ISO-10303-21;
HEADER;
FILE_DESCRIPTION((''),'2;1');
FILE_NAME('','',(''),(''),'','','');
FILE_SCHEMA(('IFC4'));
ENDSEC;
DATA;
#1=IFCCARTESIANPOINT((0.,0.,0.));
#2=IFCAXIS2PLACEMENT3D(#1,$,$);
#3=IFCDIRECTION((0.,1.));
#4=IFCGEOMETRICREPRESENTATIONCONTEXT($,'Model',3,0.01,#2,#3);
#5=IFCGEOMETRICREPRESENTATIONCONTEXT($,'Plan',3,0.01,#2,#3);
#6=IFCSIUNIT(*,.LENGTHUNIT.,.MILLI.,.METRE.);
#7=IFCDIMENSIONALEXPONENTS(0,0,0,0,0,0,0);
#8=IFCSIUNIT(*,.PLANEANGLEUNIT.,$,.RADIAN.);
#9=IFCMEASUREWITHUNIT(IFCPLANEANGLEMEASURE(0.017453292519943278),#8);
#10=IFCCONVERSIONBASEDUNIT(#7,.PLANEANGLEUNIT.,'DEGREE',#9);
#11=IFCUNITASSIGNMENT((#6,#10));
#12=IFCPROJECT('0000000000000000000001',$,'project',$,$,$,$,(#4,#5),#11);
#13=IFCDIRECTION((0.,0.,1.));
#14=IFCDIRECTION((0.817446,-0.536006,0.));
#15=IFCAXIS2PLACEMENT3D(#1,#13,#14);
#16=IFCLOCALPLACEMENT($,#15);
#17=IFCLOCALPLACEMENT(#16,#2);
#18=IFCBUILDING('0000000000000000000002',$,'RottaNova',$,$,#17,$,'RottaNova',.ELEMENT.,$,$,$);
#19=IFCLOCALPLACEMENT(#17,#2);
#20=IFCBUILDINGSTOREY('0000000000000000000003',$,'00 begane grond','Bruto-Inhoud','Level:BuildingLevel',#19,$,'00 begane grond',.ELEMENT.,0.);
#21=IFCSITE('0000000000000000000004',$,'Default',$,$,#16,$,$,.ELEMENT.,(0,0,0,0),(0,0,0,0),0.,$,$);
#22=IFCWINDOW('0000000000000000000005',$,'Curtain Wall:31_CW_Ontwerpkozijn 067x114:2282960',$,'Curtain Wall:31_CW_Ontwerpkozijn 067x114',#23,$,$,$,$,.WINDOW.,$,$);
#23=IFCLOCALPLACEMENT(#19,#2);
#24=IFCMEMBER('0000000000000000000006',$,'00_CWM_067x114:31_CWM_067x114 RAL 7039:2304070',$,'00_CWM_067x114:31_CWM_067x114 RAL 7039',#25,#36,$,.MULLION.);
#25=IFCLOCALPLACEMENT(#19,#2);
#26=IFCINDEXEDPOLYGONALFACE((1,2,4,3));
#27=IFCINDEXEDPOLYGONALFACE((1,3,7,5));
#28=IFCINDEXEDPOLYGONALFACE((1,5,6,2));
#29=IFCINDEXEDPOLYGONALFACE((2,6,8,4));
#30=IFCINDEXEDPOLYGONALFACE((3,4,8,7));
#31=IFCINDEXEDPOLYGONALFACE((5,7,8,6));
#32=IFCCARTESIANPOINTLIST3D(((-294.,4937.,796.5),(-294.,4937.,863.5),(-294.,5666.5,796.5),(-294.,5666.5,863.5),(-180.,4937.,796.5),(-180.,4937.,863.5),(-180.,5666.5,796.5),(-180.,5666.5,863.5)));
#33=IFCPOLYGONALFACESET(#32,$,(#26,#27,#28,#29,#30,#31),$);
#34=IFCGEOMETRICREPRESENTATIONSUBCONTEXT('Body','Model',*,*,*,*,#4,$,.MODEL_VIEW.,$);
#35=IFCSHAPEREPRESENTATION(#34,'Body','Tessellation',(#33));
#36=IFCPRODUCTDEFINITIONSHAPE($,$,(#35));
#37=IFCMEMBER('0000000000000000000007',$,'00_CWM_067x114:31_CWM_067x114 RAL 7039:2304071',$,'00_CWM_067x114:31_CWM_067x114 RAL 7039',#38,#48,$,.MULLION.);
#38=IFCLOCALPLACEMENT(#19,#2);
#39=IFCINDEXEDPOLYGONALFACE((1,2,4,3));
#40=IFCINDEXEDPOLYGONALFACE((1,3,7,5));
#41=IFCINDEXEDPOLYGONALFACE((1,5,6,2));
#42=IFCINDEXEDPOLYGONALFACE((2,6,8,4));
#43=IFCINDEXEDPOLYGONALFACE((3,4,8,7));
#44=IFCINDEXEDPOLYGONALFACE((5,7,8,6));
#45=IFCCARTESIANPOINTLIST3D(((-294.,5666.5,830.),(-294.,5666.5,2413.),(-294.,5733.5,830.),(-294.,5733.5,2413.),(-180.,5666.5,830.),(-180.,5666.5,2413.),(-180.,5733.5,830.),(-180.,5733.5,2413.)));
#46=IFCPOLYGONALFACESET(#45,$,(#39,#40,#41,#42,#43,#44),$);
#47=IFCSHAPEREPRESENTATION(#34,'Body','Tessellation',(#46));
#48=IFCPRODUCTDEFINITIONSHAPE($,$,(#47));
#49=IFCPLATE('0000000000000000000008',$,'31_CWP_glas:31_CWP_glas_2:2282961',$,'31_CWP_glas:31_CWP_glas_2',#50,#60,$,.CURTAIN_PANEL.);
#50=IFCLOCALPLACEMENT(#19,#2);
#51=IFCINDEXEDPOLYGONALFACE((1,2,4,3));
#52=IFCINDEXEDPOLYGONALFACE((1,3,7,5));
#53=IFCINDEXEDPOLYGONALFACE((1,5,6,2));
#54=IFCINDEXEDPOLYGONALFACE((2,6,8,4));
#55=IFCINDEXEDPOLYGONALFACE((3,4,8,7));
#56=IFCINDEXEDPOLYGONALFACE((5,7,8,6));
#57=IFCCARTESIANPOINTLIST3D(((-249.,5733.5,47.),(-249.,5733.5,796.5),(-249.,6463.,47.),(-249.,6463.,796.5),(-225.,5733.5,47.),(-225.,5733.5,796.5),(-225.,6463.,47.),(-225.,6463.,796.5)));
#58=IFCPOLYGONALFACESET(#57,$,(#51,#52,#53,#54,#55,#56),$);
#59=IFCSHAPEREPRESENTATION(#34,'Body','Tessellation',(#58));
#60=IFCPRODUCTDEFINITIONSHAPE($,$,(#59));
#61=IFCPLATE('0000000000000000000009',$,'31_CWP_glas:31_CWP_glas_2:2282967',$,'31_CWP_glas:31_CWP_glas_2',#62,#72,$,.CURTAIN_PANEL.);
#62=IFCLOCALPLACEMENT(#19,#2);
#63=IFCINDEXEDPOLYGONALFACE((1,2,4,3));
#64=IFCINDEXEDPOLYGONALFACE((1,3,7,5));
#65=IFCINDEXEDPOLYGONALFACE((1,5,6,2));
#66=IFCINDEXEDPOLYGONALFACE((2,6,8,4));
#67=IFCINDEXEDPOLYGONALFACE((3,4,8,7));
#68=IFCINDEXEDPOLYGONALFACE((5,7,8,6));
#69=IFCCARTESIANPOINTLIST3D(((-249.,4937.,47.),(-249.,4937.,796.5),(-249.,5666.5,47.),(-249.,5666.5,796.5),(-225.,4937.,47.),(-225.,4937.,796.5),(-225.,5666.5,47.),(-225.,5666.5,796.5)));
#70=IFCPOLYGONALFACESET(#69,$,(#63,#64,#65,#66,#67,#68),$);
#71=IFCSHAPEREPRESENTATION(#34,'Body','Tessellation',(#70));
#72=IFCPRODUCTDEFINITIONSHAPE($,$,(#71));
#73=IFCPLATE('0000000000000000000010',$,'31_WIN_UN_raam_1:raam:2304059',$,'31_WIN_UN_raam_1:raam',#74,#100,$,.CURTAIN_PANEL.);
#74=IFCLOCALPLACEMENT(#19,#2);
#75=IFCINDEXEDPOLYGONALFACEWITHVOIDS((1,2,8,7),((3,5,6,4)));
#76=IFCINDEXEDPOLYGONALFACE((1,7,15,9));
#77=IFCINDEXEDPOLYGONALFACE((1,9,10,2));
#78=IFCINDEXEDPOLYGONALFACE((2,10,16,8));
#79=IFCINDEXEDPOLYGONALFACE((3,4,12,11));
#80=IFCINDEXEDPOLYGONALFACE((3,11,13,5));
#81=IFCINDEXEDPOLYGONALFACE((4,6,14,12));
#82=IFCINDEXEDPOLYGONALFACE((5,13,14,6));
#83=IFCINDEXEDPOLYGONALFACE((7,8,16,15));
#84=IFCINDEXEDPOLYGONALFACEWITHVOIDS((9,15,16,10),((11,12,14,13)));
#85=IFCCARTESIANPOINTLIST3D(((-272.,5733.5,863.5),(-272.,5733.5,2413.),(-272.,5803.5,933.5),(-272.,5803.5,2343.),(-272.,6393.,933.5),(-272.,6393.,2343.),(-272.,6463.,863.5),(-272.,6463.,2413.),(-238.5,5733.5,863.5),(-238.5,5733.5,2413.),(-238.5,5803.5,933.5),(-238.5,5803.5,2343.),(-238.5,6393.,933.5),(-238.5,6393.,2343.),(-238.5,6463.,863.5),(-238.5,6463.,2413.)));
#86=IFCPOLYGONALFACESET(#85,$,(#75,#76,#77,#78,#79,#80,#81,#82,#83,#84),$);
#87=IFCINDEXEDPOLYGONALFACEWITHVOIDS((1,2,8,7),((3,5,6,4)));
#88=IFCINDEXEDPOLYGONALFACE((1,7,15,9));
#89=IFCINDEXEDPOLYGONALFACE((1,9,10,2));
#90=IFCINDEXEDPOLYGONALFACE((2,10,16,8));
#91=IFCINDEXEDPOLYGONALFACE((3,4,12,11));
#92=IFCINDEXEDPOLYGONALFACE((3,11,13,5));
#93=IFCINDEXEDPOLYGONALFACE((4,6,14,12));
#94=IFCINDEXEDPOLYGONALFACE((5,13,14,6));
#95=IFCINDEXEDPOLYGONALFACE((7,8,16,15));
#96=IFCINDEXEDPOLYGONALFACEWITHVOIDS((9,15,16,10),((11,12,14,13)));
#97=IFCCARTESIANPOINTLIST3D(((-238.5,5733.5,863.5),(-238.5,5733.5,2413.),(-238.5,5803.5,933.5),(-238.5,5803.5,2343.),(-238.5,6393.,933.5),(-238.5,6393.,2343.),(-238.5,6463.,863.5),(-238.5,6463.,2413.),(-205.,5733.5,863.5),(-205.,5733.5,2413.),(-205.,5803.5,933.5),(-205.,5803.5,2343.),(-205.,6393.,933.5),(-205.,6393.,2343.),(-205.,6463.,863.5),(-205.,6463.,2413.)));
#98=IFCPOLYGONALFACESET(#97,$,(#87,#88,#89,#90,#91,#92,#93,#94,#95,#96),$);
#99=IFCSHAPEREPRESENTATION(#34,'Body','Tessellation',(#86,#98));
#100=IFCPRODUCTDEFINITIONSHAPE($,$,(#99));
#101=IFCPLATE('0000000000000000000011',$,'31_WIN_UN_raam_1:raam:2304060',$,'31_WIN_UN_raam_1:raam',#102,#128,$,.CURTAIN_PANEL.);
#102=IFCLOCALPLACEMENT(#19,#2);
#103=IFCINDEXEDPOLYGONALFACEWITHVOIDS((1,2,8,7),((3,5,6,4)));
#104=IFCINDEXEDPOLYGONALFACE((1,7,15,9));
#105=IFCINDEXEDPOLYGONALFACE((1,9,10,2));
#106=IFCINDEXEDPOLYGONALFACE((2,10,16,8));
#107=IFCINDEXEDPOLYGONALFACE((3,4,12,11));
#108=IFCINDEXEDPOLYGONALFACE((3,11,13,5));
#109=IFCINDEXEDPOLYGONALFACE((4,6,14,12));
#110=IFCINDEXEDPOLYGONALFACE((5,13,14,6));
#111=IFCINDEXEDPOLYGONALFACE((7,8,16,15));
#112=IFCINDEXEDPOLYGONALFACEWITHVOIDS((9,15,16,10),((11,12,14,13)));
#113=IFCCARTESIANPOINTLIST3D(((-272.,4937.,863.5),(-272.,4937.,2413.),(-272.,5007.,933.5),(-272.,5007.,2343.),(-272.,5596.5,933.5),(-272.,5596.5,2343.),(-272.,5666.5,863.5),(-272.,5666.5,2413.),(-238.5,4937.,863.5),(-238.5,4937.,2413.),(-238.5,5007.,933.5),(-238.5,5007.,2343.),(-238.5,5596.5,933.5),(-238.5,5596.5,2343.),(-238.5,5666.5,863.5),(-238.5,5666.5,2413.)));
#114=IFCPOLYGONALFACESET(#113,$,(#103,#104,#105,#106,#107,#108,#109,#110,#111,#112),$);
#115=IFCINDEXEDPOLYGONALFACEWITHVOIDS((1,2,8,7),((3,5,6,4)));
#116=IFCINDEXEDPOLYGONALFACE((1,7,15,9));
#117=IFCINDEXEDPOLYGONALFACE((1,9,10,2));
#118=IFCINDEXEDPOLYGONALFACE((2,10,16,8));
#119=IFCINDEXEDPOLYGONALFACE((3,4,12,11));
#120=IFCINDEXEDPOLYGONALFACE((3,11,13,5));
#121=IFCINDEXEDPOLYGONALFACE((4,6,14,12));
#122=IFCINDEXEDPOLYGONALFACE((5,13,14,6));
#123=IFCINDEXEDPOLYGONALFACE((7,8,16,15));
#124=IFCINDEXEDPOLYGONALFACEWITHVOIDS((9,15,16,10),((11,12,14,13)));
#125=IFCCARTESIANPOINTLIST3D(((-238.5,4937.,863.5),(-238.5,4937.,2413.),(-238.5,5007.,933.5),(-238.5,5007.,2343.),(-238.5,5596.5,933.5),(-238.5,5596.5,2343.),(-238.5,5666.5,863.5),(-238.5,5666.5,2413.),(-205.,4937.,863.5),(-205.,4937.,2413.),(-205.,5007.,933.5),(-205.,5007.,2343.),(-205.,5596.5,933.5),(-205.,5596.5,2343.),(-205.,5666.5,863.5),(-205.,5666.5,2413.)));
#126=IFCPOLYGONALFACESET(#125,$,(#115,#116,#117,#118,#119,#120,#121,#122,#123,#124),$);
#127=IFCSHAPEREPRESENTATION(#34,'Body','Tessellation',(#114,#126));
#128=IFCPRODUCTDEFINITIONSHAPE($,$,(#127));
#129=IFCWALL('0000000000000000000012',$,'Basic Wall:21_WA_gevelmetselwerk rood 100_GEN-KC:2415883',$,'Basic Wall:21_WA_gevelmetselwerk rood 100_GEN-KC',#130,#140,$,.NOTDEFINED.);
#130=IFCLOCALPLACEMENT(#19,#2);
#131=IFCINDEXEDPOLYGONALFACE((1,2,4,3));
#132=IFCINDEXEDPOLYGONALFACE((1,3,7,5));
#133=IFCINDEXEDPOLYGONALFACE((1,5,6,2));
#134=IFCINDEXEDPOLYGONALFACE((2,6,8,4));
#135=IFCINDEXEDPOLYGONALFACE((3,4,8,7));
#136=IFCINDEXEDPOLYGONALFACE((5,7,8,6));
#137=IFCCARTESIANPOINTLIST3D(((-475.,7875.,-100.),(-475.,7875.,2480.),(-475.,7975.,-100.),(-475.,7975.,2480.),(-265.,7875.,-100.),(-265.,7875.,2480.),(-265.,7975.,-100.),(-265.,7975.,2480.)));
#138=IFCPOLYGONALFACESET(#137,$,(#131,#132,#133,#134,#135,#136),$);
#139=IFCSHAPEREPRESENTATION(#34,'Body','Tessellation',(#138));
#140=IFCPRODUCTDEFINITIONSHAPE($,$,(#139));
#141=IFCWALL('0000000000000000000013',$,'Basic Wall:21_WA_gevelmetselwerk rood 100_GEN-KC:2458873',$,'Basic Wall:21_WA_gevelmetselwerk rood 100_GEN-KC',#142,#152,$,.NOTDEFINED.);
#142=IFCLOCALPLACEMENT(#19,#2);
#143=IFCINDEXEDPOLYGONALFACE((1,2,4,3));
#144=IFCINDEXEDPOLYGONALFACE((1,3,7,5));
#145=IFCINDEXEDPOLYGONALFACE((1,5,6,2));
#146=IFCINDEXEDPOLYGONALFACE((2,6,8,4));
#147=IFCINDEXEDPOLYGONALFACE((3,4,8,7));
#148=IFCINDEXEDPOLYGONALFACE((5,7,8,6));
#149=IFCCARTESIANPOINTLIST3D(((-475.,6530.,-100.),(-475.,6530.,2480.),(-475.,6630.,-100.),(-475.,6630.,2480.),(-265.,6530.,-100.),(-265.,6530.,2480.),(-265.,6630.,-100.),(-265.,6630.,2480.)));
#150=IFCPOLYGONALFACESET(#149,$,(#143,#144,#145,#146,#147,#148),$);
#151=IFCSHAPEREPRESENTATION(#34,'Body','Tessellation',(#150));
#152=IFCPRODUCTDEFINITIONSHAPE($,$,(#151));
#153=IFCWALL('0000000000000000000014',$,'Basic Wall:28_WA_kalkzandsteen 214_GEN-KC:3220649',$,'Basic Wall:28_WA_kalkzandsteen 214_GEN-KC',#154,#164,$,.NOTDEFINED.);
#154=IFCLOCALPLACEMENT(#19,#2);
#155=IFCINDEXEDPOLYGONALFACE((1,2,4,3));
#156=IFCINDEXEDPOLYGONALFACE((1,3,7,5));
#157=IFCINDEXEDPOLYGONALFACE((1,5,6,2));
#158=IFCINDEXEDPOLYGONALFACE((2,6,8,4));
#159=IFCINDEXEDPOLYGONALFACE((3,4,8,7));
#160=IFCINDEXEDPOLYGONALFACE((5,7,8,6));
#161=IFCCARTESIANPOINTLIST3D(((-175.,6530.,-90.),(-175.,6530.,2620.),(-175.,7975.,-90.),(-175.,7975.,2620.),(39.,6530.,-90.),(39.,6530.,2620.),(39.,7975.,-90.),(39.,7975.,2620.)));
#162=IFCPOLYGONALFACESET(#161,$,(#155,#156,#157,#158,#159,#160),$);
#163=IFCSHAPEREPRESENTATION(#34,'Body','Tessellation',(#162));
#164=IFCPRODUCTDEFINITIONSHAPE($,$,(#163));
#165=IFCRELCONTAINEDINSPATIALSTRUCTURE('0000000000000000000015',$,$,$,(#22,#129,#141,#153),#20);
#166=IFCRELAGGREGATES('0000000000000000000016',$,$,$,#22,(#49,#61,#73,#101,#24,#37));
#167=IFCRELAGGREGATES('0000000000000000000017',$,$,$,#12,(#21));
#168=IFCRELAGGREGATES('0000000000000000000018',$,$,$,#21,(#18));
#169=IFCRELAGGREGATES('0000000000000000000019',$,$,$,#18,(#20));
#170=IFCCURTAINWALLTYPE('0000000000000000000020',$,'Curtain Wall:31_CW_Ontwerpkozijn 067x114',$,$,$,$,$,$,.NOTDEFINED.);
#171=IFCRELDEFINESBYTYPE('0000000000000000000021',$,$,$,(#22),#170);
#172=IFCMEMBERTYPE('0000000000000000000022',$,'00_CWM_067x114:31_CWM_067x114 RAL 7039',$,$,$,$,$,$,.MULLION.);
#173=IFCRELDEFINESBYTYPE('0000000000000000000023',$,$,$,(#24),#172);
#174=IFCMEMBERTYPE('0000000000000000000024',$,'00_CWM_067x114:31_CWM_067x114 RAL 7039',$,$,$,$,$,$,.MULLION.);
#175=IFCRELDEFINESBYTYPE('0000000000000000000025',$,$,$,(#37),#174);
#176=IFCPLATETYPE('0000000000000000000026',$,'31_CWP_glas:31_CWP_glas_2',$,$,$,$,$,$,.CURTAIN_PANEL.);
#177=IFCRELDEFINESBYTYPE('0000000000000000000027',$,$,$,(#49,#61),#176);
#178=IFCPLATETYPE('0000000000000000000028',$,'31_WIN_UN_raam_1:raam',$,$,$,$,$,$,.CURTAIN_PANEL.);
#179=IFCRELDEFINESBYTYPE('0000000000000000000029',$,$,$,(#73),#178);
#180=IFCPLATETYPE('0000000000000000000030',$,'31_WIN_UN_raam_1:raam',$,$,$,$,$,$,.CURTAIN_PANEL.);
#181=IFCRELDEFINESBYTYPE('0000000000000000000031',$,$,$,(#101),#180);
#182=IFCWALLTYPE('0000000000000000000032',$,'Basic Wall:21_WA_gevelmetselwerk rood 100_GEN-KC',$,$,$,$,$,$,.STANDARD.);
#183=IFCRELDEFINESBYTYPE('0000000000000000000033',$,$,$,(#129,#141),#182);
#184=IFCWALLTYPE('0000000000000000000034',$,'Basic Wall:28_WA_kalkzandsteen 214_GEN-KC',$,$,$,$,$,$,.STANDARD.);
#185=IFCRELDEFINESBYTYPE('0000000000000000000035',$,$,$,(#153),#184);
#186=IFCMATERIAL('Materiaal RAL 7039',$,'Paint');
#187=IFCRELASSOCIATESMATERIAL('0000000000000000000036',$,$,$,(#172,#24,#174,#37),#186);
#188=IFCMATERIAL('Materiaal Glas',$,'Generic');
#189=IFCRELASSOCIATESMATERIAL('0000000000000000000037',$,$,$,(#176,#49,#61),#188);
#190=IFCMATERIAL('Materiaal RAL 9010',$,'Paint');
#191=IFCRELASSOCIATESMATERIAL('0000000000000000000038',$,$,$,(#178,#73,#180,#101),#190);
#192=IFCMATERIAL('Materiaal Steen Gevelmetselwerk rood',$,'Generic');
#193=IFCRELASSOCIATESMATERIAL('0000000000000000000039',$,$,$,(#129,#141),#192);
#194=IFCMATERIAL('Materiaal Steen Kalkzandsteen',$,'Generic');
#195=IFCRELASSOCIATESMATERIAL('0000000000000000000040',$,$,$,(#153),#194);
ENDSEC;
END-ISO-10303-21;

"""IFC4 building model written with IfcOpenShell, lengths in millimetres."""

from ifc_helpers import new_model, entity, si_unit, converted_unit, direction, frame, origin, place, context, subcontext, project, spatial, indexed_curve, outline, extrude, source, transform, mapped, material, type_object, type_shapes, element, aggregate, save


model = new_model("IFC4")

# Units and contexts
model_context = context("Model", 3, precision=0.01, world=origin(), true_north=direction((0.0, 1.0)))
plan_context = context("Plan", 3, precision=0.01, world=origin(), true_north=direction((0.0, 1.0)))
body_context = subcontext(model_context, "Body", "Model", "MODEL_VIEW")
ifc_project = project(units=[si_unit("LENGTHUNIT", "METRE", prefix="MILLI"), converted_unit("PLANEANGLEUNIT", "DEGREE", entity("IfcPlaneAngleMeasure", 0.017453292519943278), si_unit("PLANEANGLEUNIT", "RADIAN"), dimensions=[0, 0, 0, 0, 0, 0, 0])], contexts=[model_context, plan_context])

# Site, building, storey
site_placement = place(None, frame((0.0, 0.0, 0.0), z_axis=(0.0, 0.0, 1.0), x_axis=(0.817446, -0.536006, 0.0)))
site = spatial("IfcSite", under=ifc_project, at=site_placement, Name="Default", CompositionType="ELEMENT", RefLatitude=(0, 0, 0, 0), RefLongitude=(0, 0, 0, 0), RefElevation=0.0)
building_placement = place(site_placement, origin())
building = spatial("IfcBuilding", under=site, at=building_placement, Name="RottaNova", LongName="RottaNova", CompositionType="ELEMENT")
storey_placement = place(building_placement, origin())
storey = spatial("IfcBuildingStorey", under=building, at=storey_placement, Name="00 begane grond", Description="Bruto-Inhoud", ObjectType="Level:BuildingLevel", LongName="00 begane grond", CompositionType="ELEMENT", Elevation=0.0)

# Window, members, plates
curtain_wall_type = type_object("IfcCurtainWallType", Name="Curtain Wall:31_CW_Ontwerpkozijn 067x114", PredefinedType="NOTDEFINED")
window_placement = place(storey_placement, origin())
window = element("IfcWindow", 1, at=window_placement, inside=storey, type_object=curtain_wall_type, Name="Curtain Wall:31_CW_Ontwerpkozijn 067x114:2282960", ObjectType="Curtain Wall:31_CW_Ontwerpkozijn 067x114", PredefinedType="WINDOW")
ifc_material_1 = material(Name="Materiaal RAL 7039", Category="Paint")
member_type_1 = type_object("IfcMemberType", Name="00_CWM_067x114:31_CWM_067x114 RAL 7039", PredefinedType="MULLION", material=ifc_material_1)
shared_shape_1 = source(origin(), body_context, "Body", "SweptSolid", [
    extrude(outline(indexed_curve([(-33.5, -57.0), (33.5, -57.0), (33.5, 57.0), (-33.5, 57.0), (-33.5, -57.0)], self_intersect=False)), frame((0.0, 57.0, -729.5), z_axis=(0.0, 0.0, 1.0), x_axis=(-1.0, 0.0, 0.0)), (0.0, 0.0, 1.0), 729.5),
])
type_shapes(member_type_1, [shared_shape_1])
member_1_placement = place(window_placement, frame((-180.0, 4937.0, 830.0), z_axis=(0.0, -1.0, 0.0), x_axis=(0.0, 0.0, 1.0)))
member_1 = element("IfcMember", 2, at=member_1_placement, type_object=member_type_1, material=ifc_material_1, Name="00_CWM_067x114:31_CWM_067x114 RAL 7039:2304070", ObjectType="00_CWM_067x114:31_CWM_067x114 RAL 7039", PredefinedType="MULLION", context=body_context, shape_type="MappedRepresentation", body=[
    mapped(shared_shape_1, transform((0.0, 0.0, 0.0), scale=1.0)),
])
member_type_2 = type_object("IfcMemberType", Name="00_CWM_067x114:31_CWM_067x114 RAL 7039", PredefinedType="MULLION", material=ifc_material_1)
shared_shape_2 = source(origin(), body_context, "Body", "SweptSolid", [
    extrude(outline(indexed_curve([(-33.5, -57.0), (33.5, -57.0), (33.5, 57.0), (-33.5, 57.0), (-33.5, -57.0)], self_intersect=False)), frame((0.0, 57.0, -1583.0), z_axis=(0.0, 0.0, 1.0), x_axis=(-1.0, 0.0, 0.0)), (0.0, 0.0, 1.0), 1583.0),
])
type_shapes(member_type_2, [shared_shape_2])
member_2_placement = place(window_placement, frame((-180.0, 5700.0, 830.0), z_axis=(0.0, 0.0, -1.0), x_axis=(0.0, -1.0, 0.0)))
member_2 = element("IfcMember", 3, at=member_2_placement, type_object=member_type_2, material=ifc_material_1, Name="00_CWM_067x114:31_CWM_067x114 RAL 7039:2304071", ObjectType="00_CWM_067x114:31_CWM_067x114 RAL 7039", PredefinedType="MULLION", context=body_context, shape_type="MappedRepresentation", body=[
    mapped(shared_shape_2, transform((0.0, 0.0, 0.0), scale=1.0)),
])
ifc_material_2 = material(Name="Materiaal Glas", Category="Generic")
plate_type_1 = type_object("IfcPlateType", Name="31_CWP_glas:31_CWP_glas_2", PredefinedType="CURTAIN_PANEL", material=ifc_material_2)
shared_shape_3 = source(origin(), body_context, "Body", "SweptSolid", [
    extrude(outline(indexed_curve([(-12.0, -364.7), (12.0, -364.7), (12.0, 364.7), (-12.0, 364.7), (-12.0, -364.7)], self_intersect=False)), frame((0.0, -57.0, 0.0), z_axis=(0.0, 0.0, 1.0), x_axis=(0.0, 1.0, 0.0)), (0.0, 0.0, 1.0), 749.5),
])
type_shapes(plate_type_1, [shared_shape_3])
plate_1_placement = place(window_placement, frame((-180.0, 6098.2, 47.0), z_axis=(0.0, 0.0, 1.0), x_axis=(0.0, -1.0, 0.0)))
plate_1 = element("IfcPlate", 4, at=plate_1_placement, type_object=plate_type_1, material=ifc_material_2, Name="31_CWP_glas:31_CWP_glas_2:2282961", ObjectType="31_CWP_glas:31_CWP_glas_2", PredefinedType="CURTAIN_PANEL", context=body_context, shape_type="MappedRepresentation", body=[
    mapped(shared_shape_3, transform((0.0, 0.0, 0.0), scale=1.0)),
])
plate_2_placement = place(window_placement, frame((-180.0, 5301.7, 47.0), z_axis=(0.0, 0.0, 1.0), x_axis=(0.0, -1.0, 0.0)))
plate_2 = element("IfcPlate", 5, at=plate_2_placement, type_object=plate_type_1, material=ifc_material_2, Name="31_CWP_glas:31_CWP_glas_2:2282967", ObjectType="31_CWP_glas:31_CWP_glas_2", PredefinedType="CURTAIN_PANEL", context=body_context, shape_type="MappedRepresentation", body=[
    mapped(shared_shape_3, transform((0.0, 0.0, 0.0), scale=1.0)),
])
ifc_material_3 = material(Name="Materiaal RAL 9010", Category="Paint")
plate_type_2 = type_object("IfcPlateType", Name="31_WIN_UN_raam_1:raam", PredefinedType="CURTAIN_PANEL", material=ifc_material_3)
shared_shape_4 = source(origin(), body_context, "Body", "SweptSolid", [
    extrude(outline(indexed_curve([(-364.7, -774.7), (364.7, -774.7), (364.7, 774.7), (-364.7, 774.7), (-364.7, -774.7)], self_intersect=False), holes=[indexed_curve([(-294.7, 704.7), (294.7, 704.7), (294.7, -704.8), (-294.7, -704.8), (-294.7, 704.7)], self_intersect=False)]), frame((0.0, -92.0, 774.8), z_axis=(0.0, 1.0, 0.0), x_axis=(1.0, 0.0, 0.0)), (0.0, 0.0, 1.0), 33.5),
    extrude(outline(indexed_curve([(-364.7, -774.7), (364.7, -774.7), (364.7, 774.7), (-364.7, 774.7), (-364.7, -774.7)], self_intersect=False), holes=[indexed_curve([(-294.7, 704.7), (294.7, 704.7), (294.7, -704.8), (-294.7, -704.8), (-294.7, 704.7)], self_intersect=False)]), frame((0.0, -58.5, 774.8), z_axis=(0.0, 1.0, 0.0), x_axis=(1.0, 0.0, 0.0)), (0.0, 0.0, 1.0), 33.5),
])
type_shapes(plate_type_2, [shared_shape_4])
plate_3_placement = place(window_placement, frame((-180.0, 6098.2, 863.5), z_axis=(0.0, 0.0, 1.0), x_axis=(0.0, -1.0, 0.0)))
plate_3 = element("IfcPlate", 6, at=plate_3_placement, type_object=plate_type_2, material=ifc_material_3, Name="31_WIN_UN_raam_1:raam:2304059", ObjectType="31_WIN_UN_raam_1:raam", PredefinedType="CURTAIN_PANEL", context=body_context, shape_type="MappedRepresentation", body=[
    mapped(shared_shape_4, transform((0.0, 0.0, 0.0), scale=1.0)),
])
plate_type_3 = type_object("IfcPlateType", Name="31_WIN_UN_raam_1:raam", PredefinedType="CURTAIN_PANEL", material=ifc_material_3)
shared_shape_5 = source(origin(), body_context, "Body", "SweptSolid", [
    extrude(outline(indexed_curve([(-364.7, -774.7), (364.7, -774.7), (364.7, 774.7), (-364.7, 774.7), (-364.7, -774.7)], self_intersect=False), holes=[indexed_curve([(-294.7, 704.7), (294.7, 704.7), (294.7, -704.8), (-294.7, -704.8), (-294.7, 704.7)], self_intersect=False)]), frame((0.0, -92.0, 774.8), z_axis=(0.0, 1.0, 0.0), x_axis=(1.0, 0.0, 0.0)), (0.0, 0.0, 1.0), 33.5),
    extrude(outline(indexed_curve([(-364.7, -774.7), (364.7, -774.7), (364.7, 774.7), (-364.7, 774.7), (-364.7, -774.7)], self_intersect=False), holes=[indexed_curve([(-294.7, 704.7), (294.7, 704.7), (294.7, -704.8), (-294.7, -704.8), (-294.7, 704.7)], self_intersect=False)]), frame((0.0, -58.5, 774.8), z_axis=(0.0, 1.0, 0.0), x_axis=(1.0, 0.0, 0.0)), (0.0, 0.0, 1.0), 33.5),
])
type_shapes(plate_type_3, [shared_shape_5])
plate_4_placement = place(window_placement, frame((-180.0, 5301.7, 863.5), z_axis=(0.0, 0.0, 1.0), x_axis=(0.0, -1.0, 0.0)))
plate_4 = element("IfcPlate", 7, at=plate_4_placement, type_object=plate_type_3, material=ifc_material_3, Name="31_WIN_UN_raam_1:raam:2304060", ObjectType="31_WIN_UN_raam_1:raam", PredefinedType="CURTAIN_PANEL", context=body_context, shape_type="MappedRepresentation", body=[
    mapped(shared_shape_5, transform((0.0, 0.0, 0.0), scale=1.0)),
])
aggregate(window, [plate_1, plate_2, plate_3, plate_4, member_1, member_2])

# Walls
ifc_material_4 = material(Name="Materiaal Steen Gevelmetselwerk rood", Category="Generic")
wall_type_1 = type_object("IfcWallType", Name="Basic Wall:21_WA_gevelmetselwerk rood 100_GEN-KC", PredefinedType="STANDARD")
wall_1_placement = place(storey_placement, frame((-475.0, 7925.0, -100.0)))
element("IfcWall", 8, at=wall_1_placement, inside=storey, type_object=wall_type_1, material=ifc_material_4, Name="Basic Wall:21_WA_gevelmetselwerk rood 100_GEN-KC:2415883", ObjectType="Basic Wall:21_WA_gevelmetselwerk rood 100_GEN-KC", PredefinedType="NOTDEFINED", context=body_context, shape_type="SweptSolid", body=[
    extrude(outline(indexed_curve([(210.0, 50.0), (0.0, 50.0), (0.0, -50.0), (210.0, -50.0), (210.0, 50.0)], self_intersect=False)), origin(), (0.0, 0.0, 1.0), 2580.0),
])
wall_2_placement = place(storey_placement, frame((-475.0, 6580.0, -100.0)))
element("IfcWall", 9, at=wall_2_placement, inside=storey, type_object=wall_type_1, material=ifc_material_4, Name="Basic Wall:21_WA_gevelmetselwerk rood 100_GEN-KC:2458873", ObjectType="Basic Wall:21_WA_gevelmetselwerk rood 100_GEN-KC", PredefinedType="NOTDEFINED", context=body_context, shape_type="SweptSolid", body=[
    extrude(outline(indexed_curve([(210.0, 50.0), (0.0, 50.0), (0.0, -50.0), (210.0, -50.0), (210.0, 50.0)], self_intersect=False)), origin(), (0.0, 0.0, 1.0), 2580.0),
])
ifc_material_5 = material(Name="Materiaal Steen Kalkzandsteen", Category="Generic")
wall_type_2 = type_object("IfcWallType", Name="Basic Wall:28_WA_kalkzandsteen 214_GEN-KC", PredefinedType="STANDARD")
wall_3_placement = place(storey_placement, frame((-68.0, 6530.0, -90.0), z_axis=(0.0, 0.0, 1.0), x_axis=(0.0, 1.0, 0.0)))
element("IfcWall", 10, at=wall_3_placement, inside=storey, type_object=wall_type_2, material=ifc_material_5, Name="Basic Wall:28_WA_kalkzandsteen 214_GEN-KC:3220649", ObjectType="Basic Wall:28_WA_kalkzandsteen 214_GEN-KC", PredefinedType="NOTDEFINED", context=body_context, shape_type="SweptSolid", body=[
    extrude(outline(indexed_curve([(1445.0, 107.0), (0.0, 107.0), (0.0, -107.0), (1445.0, -107.0), (1445.0, 107.0)], self_intersect=False)), origin(), (0.0, 0.0, 1.0), 2710.0),
])

save(model, "model.ifc")
